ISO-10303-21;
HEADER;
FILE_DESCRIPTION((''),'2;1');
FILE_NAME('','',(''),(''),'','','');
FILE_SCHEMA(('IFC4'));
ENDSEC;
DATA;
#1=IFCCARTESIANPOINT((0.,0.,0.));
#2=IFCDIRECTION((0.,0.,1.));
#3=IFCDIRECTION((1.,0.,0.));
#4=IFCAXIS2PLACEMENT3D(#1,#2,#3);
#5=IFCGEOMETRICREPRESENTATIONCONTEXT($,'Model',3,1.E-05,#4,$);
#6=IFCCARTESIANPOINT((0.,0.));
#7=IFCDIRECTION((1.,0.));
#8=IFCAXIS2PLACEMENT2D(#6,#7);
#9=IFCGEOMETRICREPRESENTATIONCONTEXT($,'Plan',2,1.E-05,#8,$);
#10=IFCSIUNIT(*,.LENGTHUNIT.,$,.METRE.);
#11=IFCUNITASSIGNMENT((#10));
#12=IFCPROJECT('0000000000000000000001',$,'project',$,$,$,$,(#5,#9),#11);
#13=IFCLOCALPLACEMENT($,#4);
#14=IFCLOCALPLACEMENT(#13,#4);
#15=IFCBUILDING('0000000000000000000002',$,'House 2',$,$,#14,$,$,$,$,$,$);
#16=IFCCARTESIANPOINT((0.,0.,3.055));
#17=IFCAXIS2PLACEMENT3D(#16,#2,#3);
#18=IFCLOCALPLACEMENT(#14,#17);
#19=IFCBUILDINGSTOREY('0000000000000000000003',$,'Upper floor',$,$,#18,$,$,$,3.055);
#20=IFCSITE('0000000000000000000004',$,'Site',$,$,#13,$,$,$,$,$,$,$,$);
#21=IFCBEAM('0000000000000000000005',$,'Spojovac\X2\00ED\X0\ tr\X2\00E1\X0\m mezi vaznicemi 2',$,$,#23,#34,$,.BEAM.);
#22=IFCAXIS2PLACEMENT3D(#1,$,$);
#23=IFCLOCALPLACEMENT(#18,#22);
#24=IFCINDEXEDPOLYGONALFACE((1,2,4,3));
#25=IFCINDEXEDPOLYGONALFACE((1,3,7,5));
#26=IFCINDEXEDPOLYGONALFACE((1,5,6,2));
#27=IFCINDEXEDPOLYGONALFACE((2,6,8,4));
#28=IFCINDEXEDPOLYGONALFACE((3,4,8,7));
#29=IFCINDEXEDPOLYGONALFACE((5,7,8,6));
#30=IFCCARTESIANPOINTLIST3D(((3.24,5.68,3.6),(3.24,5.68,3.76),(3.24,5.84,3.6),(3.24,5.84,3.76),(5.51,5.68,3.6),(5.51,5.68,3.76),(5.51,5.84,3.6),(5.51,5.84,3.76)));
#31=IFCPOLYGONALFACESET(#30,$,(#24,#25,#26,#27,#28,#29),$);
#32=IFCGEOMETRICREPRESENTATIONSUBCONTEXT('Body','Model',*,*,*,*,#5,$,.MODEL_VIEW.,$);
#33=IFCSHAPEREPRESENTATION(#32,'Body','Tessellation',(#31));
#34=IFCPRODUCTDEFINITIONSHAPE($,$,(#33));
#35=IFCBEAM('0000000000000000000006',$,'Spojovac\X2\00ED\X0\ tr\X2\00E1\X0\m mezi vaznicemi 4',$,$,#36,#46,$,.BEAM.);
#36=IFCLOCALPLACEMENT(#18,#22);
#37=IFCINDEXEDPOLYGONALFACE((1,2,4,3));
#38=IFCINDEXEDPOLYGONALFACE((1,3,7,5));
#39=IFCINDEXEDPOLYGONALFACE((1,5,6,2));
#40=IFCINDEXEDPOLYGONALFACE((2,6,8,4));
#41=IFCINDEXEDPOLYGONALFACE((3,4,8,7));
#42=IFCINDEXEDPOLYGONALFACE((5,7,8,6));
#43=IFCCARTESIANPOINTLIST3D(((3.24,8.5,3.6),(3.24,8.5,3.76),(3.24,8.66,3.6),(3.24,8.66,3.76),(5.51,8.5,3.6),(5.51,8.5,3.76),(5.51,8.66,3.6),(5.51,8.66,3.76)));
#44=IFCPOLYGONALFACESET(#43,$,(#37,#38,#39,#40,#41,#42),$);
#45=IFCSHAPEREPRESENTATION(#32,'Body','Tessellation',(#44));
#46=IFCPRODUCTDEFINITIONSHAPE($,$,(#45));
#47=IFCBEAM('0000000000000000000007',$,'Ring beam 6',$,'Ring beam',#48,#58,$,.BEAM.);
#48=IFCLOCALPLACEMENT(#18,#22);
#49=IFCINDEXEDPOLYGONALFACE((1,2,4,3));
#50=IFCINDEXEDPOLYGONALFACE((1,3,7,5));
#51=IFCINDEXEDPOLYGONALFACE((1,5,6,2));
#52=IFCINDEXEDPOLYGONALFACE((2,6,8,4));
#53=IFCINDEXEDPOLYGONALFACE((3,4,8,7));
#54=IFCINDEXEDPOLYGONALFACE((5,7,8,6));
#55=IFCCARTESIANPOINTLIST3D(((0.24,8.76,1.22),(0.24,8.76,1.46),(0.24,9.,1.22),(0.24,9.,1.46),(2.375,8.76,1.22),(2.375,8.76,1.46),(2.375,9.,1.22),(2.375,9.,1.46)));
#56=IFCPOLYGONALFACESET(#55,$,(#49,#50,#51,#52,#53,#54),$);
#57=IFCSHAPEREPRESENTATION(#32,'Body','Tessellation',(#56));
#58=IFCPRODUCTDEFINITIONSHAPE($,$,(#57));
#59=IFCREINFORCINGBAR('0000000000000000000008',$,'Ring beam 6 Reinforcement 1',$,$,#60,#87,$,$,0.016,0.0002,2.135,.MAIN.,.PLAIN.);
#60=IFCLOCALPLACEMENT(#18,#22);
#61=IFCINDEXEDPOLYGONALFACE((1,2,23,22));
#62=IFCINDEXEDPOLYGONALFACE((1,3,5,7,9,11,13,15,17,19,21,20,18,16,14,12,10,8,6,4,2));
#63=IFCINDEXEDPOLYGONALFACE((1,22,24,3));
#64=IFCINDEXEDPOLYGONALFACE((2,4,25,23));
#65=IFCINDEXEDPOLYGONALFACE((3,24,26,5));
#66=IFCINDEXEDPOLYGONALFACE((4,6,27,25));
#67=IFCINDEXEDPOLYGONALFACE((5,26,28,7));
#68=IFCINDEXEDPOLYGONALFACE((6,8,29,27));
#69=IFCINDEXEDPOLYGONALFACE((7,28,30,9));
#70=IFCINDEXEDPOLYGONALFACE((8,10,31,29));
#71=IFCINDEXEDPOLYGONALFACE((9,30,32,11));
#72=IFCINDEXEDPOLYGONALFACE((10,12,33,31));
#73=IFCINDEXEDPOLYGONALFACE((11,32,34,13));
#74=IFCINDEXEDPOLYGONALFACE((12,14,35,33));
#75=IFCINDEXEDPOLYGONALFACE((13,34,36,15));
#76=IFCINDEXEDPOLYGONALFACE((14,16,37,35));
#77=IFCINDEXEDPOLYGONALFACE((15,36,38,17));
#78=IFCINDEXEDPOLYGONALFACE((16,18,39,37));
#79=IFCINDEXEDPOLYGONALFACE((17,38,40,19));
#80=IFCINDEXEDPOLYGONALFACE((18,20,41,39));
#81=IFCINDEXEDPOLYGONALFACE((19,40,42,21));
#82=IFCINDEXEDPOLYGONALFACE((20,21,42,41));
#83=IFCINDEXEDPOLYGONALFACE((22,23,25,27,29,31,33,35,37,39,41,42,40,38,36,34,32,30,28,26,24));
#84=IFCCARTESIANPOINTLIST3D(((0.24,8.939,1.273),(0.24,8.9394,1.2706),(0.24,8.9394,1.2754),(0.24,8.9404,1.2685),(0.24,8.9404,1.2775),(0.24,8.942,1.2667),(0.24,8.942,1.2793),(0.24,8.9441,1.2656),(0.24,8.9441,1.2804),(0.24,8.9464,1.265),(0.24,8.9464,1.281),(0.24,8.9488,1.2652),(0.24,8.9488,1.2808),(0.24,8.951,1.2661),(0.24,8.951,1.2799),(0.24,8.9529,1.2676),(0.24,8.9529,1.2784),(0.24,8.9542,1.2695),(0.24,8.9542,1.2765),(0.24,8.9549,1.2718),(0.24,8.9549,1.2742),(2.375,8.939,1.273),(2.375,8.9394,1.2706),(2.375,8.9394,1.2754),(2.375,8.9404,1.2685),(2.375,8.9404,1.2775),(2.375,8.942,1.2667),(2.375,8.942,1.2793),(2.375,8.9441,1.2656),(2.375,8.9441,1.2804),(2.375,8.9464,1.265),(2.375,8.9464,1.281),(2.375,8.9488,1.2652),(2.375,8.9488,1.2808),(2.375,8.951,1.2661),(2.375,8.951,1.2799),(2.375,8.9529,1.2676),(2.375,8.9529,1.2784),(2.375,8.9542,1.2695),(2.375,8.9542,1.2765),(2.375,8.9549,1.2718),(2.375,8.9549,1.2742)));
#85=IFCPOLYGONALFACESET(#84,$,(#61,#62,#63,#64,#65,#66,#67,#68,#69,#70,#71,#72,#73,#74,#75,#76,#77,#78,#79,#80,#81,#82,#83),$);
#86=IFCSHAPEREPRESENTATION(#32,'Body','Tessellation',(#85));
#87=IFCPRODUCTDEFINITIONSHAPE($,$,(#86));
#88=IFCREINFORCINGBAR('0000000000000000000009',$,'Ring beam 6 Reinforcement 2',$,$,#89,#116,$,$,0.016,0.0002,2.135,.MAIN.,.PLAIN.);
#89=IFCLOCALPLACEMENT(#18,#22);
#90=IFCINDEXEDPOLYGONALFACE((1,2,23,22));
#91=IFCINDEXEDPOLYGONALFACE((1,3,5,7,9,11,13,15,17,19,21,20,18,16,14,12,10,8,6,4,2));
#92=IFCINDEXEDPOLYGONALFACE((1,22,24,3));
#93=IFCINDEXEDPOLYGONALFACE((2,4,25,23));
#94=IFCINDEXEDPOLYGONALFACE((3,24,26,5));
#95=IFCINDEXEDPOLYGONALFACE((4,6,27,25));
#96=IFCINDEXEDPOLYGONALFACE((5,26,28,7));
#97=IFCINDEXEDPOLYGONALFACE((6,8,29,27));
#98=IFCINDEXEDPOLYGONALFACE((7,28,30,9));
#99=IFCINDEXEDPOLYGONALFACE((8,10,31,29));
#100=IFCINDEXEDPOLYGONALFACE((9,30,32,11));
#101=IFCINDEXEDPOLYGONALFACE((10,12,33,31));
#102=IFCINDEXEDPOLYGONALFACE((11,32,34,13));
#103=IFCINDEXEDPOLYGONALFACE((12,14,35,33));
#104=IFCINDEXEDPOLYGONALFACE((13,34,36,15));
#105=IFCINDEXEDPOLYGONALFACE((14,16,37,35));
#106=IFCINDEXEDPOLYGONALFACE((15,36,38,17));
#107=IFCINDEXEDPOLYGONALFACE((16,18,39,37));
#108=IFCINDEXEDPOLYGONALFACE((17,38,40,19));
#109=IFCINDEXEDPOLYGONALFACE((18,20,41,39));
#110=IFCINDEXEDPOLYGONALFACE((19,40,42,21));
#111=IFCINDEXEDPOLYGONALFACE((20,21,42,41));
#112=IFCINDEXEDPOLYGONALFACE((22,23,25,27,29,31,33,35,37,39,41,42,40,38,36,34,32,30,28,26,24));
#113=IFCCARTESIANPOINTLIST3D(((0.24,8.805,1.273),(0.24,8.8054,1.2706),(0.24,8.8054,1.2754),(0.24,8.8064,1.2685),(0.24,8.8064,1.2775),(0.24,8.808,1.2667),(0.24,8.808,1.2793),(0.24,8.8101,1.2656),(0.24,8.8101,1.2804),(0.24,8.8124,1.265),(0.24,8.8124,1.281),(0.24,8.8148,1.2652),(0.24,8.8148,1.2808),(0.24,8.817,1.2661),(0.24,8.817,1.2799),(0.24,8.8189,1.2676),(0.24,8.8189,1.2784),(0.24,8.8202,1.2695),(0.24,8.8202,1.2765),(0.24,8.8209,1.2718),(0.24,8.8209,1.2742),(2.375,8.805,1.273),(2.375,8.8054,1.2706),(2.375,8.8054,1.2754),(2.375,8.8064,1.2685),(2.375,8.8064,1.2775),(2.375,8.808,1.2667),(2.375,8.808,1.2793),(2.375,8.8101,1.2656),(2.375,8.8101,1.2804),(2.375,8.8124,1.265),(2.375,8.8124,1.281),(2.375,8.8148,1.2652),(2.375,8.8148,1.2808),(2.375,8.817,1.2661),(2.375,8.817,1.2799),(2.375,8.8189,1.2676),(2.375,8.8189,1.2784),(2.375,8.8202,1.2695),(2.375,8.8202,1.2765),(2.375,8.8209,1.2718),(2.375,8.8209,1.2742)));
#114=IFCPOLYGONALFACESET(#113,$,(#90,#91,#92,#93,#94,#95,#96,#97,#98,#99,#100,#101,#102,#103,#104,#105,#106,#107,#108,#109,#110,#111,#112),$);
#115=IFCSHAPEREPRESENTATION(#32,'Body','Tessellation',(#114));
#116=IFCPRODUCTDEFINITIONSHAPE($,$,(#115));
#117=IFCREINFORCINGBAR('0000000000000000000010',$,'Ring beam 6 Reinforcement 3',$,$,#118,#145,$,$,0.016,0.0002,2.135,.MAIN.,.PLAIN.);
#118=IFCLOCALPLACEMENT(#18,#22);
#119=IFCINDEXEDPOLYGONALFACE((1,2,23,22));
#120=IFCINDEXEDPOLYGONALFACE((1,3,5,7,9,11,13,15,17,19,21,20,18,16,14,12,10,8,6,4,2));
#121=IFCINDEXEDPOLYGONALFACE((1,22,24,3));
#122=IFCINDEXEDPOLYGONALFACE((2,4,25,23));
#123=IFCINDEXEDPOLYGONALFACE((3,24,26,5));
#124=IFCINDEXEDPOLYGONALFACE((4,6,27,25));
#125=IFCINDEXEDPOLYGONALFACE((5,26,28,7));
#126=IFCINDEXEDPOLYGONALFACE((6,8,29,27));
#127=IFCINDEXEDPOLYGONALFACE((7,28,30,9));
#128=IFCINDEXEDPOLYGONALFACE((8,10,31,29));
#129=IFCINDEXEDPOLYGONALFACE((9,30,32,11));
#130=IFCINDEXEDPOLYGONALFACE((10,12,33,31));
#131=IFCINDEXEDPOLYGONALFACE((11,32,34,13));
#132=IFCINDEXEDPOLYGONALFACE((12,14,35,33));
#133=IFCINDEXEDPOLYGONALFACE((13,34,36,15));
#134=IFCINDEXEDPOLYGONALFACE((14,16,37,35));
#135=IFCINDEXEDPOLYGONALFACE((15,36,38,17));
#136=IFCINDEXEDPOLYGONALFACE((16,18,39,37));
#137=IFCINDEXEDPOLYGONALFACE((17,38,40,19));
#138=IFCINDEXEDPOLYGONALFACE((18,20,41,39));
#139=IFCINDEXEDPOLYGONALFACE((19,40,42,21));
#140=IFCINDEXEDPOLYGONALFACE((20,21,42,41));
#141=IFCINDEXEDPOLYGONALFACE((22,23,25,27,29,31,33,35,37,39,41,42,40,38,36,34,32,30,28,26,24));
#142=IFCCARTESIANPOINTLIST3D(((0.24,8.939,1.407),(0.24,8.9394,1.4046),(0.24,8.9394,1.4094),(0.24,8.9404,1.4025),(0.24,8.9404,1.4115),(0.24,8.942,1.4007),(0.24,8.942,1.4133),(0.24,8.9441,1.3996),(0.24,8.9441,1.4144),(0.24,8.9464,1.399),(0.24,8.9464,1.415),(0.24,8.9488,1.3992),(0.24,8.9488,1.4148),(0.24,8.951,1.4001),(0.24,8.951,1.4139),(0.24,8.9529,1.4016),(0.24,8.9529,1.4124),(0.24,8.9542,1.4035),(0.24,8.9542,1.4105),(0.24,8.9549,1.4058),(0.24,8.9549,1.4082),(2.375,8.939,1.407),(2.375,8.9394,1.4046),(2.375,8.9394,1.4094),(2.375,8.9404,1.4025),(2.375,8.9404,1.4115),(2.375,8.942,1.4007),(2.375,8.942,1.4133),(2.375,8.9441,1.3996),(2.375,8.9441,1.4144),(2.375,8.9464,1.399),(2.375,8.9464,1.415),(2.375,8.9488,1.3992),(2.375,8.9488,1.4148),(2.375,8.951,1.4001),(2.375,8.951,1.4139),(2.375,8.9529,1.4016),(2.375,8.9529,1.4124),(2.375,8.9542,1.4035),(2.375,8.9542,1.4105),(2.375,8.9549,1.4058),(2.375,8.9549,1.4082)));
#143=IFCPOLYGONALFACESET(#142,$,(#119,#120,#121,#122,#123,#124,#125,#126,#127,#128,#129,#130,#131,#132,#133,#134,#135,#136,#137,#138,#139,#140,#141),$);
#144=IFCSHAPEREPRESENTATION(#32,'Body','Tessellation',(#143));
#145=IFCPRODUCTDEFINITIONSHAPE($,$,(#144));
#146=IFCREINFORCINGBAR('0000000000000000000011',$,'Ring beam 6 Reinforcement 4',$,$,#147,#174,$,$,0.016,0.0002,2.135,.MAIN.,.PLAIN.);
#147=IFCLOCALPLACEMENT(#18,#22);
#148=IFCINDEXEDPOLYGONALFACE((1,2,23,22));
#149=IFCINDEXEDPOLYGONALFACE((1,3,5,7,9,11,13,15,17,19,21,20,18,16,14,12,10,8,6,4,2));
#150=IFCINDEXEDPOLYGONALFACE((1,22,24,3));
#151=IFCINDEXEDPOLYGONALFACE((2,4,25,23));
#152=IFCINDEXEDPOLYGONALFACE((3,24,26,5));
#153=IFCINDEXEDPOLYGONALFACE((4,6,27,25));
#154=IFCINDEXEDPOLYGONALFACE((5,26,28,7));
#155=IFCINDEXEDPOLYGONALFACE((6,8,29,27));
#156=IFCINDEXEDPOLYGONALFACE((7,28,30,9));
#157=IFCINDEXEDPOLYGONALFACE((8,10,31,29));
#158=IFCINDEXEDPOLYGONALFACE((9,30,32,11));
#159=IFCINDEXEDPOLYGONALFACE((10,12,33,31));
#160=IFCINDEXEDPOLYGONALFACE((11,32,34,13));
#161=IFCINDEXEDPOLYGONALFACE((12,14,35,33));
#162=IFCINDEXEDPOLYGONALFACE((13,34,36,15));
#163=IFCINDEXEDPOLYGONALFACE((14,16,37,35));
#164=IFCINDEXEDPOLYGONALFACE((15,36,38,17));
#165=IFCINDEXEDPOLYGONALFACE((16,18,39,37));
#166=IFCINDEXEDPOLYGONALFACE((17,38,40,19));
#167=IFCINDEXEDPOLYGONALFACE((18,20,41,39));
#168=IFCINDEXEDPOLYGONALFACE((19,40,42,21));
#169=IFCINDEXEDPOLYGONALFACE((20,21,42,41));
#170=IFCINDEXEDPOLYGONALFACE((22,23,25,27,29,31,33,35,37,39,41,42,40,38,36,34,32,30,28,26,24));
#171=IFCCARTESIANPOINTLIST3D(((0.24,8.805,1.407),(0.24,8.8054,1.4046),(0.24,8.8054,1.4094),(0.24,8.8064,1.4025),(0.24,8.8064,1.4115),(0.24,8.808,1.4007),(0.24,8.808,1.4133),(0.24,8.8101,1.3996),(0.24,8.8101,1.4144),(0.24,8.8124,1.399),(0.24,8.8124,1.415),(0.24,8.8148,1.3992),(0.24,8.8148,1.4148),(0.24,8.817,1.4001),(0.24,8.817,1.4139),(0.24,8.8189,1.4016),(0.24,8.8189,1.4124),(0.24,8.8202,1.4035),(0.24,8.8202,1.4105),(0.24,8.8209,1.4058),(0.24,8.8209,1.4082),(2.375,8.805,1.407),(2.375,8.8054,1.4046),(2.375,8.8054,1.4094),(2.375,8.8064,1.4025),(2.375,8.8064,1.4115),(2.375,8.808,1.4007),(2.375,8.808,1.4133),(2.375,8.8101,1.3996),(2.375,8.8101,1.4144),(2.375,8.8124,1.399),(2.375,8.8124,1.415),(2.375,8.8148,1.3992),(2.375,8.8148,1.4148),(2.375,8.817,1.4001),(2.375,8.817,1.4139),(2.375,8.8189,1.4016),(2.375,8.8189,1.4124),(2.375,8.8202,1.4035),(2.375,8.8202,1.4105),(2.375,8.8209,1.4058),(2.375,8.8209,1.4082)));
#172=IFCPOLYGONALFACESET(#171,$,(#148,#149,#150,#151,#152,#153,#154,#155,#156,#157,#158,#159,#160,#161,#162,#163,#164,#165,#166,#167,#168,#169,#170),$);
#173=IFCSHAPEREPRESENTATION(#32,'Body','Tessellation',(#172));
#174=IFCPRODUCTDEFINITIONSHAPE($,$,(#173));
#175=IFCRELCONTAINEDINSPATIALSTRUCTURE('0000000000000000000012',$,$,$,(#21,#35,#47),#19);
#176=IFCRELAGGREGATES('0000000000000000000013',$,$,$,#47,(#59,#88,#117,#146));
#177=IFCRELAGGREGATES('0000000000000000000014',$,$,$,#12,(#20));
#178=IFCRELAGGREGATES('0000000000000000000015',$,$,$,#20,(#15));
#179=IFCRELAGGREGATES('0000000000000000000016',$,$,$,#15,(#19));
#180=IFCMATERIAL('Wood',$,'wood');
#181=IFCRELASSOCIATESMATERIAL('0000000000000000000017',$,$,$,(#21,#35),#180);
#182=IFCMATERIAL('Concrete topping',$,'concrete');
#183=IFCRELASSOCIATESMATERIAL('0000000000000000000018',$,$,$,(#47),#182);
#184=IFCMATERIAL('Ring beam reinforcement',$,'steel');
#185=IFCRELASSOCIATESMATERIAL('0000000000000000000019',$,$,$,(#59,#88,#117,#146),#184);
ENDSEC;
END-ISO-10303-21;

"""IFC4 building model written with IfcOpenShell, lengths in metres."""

from ifc_helpers import new_model, si_unit, frame, origin_with_axes, origin_2d, origin_2d_with_axis, place, context, subcontext, project, spatial, circle_curve, rectangle, outline, extrude, material, element, aggregate, save


model = new_model("IFC4")

# Units and contexts
model_context = context("Model", 3, precision=1e-05, world=origin_with_axes())
plan_context = context("Plan", 2, precision=1e-05, world=origin_2d_with_axis())
body_context_1 = subcontext(model_context, "Body", "Model", "MODEL_VIEW")
ifc_project = project(units=[si_unit("LENGTHUNIT", "METRE")], contexts=[model_context, plan_context])

# Site, building, storey
site_placement = place(None, origin_with_axes())
site = spatial("IfcSite", under=ifc_project, at=site_placement, Name="Site")
building_placement = place(site_placement, origin_with_axes())
building = spatial("IfcBuilding", under=site, at=building_placement, Name="House 2")
storey_placement = place(building_placement, frame((0.0, 0.0, 3.055), z_axis=(0.0, 0.0, 1.0), x_axis=(1.0, 0.0, 0.0)))
storey = spatial("IfcBuildingStorey", under=building, at=storey_placement, Name="Upper floor", Elevation=3.055)

# Beams
ifc_material_1 = material(Name="Wood", Category="wood")
for number, where, z_axis, x_axis, name in (
    (1, (3.24, 5.76, 3.68), (0.0, 0.0, 1.0), (1.0, 0.0, 0.0), "Spojovací trám mezi vaznicemi 2"),
    (2, (3.24, 8.58, 3.68), (0.0, 0.0, 1.0), (1.0, 0.0, 0.0), "Spojovací trám mezi vaznicemi 4"),
):
    element("IfcBeam", number, at=place(storey_placement, frame(where, z_axis=z_axis, x_axis=x_axis)), inside=storey, material=ifc_material_1, Name=name, PredefinedType="BEAM", context=body_context_1, shape_type="SweptSolid", body=[
        extrude(rectangle(XDim=0.16, YDim=0.16), frame((0.0, 0.0, 0.0), z_axis=(1.0, 0.0, 0.0), x_axis=(0.0, 1.0, 0.0)), (0.0, 0.0, 1.0), 2.27),
    ])

# Beam
ifc_material_2 = material(Name="Concrete topping", Category="concrete")
beam_1_placement = place(storey_placement, frame((2.375, 8.88, 1.34), z_axis=(0.0, 0.0, 1.0), x_axis=(-1.0, 0.0, 0.0)))
beam_1 = element("IfcBeam", 3, at=beam_1_placement, inside=storey, material=ifc_material_2, Name="Ring beam 6", ObjectType="Ring beam", PredefinedType="BEAM", context=body_context_1, shape_type="SweptSolid", body=[
    extrude(rectangle(XDim=0.24, YDim=0.24), frame((0.0, 0.0, 0.0), z_axis=(1.0, 0.0, 0.0), x_axis=(0.0, 1.0, 0.0)), (0.0, 0.0, 1.0), 2.135),
])

# Reinforcing bars
ifc_material_3 = material(Name="Ring beam reinforcement", Category="steel")
reinforcing_bar_1_placement = place(beam_1_placement, frame((0.0, -0.067, -0.067), z_axis=(0.0, 0.0, 1.0), x_axis=(1.0, 0.0, 0.0)))
reinforcing_bar_1 = element("IfcReinforcingBar", 4, at=reinforcing_bar_1_placement, material=ifc_material_3, Name="Ring beam 6 Reinforcement 1", BarLength=2.135, BarSurface="PLAIN", CrossSectionArea=0.0002, NominalDiameter=0.016, PredefinedType="MAIN", context=body_context_1, shape_type="SweptSolid", body=[
    extrude(outline(circle_curve(origin_2d(), 0.008)), frame((0.0, 0.0, 0.0), z_axis=(1.0, 0.0, 0.0), x_axis=(0.0, 1.0, 0.0)), (0.0, 0.0, 1.0), 2.135),
])
reinforcing_bar_2_placement = place(beam_1_placement, frame((0.0, 0.067, -0.067), z_axis=(0.0, 0.0, 1.0), x_axis=(1.0, 0.0, 0.0)))
reinforcing_bar_2 = element("IfcReinforcingBar", 5, at=reinforcing_bar_2_placement, material=ifc_material_3, Name="Ring beam 6 Reinforcement 2", BarLength=2.135, BarSurface="PLAIN", CrossSectionArea=0.0002, NominalDiameter=0.016, PredefinedType="MAIN", context=body_context_1, shape_type="SweptSolid", body=[
    extrude(outline(circle_curve(origin_2d(), 0.008)), frame((0.0, 0.0, 0.0), z_axis=(1.0, 0.0, 0.0), x_axis=(0.0, 1.0, 0.0)), (0.0, 0.0, 1.0), 2.135),
])
reinforcing_bar_3_placement = place(beam_1_placement, frame((0.0, -0.067, 0.067), z_axis=(0.0, 0.0, 1.0), x_axis=(1.0, 0.0, 0.0)))
reinforcing_bar_3 = element("IfcReinforcingBar", 6, at=reinforcing_bar_3_placement, material=ifc_material_3, Name="Ring beam 6 Reinforcement 3", BarLength=2.135, BarSurface="PLAIN", CrossSectionArea=0.0002, NominalDiameter=0.016, PredefinedType="MAIN", context=body_context_1, shape_type="SweptSolid", body=[
    extrude(outline(circle_curve(origin_2d(), 0.008)), frame((0.0, 0.0, 0.0), z_axis=(1.0, 0.0, 0.0), x_axis=(0.0, 1.0, 0.0)), (0.0, 0.0, 1.0), 2.135),
])
reinforcing_bar_4_placement = place(beam_1_placement, frame((0.0, 0.067, 0.067), z_axis=(0.0, 0.0, 1.0), x_axis=(1.0, 0.0, 0.0)))
reinforcing_bar_4 = element("IfcReinforcingBar", 7, at=reinforcing_bar_4_placement, material=ifc_material_3, Name="Ring beam 6 Reinforcement 4", BarLength=2.135, BarSurface="PLAIN", CrossSectionArea=0.0002, NominalDiameter=0.016, PredefinedType="MAIN", context=body_context_1, shape_type="SweptSolid", body=[
    extrude(outline(circle_curve(origin_2d(), 0.008)), frame((0.0, 0.0, 0.0), z_axis=(1.0, 0.0, 0.0), x_axis=(0.0, 1.0, 0.0)), (0.0, 0.0, 1.0), 2.135),
])
aggregate(beam_1, [reinforcing_bar_1, reinforcing_bar_2, reinforcing_bar_3, reinforcing_bar_4])

save(model, "model.ifc")
